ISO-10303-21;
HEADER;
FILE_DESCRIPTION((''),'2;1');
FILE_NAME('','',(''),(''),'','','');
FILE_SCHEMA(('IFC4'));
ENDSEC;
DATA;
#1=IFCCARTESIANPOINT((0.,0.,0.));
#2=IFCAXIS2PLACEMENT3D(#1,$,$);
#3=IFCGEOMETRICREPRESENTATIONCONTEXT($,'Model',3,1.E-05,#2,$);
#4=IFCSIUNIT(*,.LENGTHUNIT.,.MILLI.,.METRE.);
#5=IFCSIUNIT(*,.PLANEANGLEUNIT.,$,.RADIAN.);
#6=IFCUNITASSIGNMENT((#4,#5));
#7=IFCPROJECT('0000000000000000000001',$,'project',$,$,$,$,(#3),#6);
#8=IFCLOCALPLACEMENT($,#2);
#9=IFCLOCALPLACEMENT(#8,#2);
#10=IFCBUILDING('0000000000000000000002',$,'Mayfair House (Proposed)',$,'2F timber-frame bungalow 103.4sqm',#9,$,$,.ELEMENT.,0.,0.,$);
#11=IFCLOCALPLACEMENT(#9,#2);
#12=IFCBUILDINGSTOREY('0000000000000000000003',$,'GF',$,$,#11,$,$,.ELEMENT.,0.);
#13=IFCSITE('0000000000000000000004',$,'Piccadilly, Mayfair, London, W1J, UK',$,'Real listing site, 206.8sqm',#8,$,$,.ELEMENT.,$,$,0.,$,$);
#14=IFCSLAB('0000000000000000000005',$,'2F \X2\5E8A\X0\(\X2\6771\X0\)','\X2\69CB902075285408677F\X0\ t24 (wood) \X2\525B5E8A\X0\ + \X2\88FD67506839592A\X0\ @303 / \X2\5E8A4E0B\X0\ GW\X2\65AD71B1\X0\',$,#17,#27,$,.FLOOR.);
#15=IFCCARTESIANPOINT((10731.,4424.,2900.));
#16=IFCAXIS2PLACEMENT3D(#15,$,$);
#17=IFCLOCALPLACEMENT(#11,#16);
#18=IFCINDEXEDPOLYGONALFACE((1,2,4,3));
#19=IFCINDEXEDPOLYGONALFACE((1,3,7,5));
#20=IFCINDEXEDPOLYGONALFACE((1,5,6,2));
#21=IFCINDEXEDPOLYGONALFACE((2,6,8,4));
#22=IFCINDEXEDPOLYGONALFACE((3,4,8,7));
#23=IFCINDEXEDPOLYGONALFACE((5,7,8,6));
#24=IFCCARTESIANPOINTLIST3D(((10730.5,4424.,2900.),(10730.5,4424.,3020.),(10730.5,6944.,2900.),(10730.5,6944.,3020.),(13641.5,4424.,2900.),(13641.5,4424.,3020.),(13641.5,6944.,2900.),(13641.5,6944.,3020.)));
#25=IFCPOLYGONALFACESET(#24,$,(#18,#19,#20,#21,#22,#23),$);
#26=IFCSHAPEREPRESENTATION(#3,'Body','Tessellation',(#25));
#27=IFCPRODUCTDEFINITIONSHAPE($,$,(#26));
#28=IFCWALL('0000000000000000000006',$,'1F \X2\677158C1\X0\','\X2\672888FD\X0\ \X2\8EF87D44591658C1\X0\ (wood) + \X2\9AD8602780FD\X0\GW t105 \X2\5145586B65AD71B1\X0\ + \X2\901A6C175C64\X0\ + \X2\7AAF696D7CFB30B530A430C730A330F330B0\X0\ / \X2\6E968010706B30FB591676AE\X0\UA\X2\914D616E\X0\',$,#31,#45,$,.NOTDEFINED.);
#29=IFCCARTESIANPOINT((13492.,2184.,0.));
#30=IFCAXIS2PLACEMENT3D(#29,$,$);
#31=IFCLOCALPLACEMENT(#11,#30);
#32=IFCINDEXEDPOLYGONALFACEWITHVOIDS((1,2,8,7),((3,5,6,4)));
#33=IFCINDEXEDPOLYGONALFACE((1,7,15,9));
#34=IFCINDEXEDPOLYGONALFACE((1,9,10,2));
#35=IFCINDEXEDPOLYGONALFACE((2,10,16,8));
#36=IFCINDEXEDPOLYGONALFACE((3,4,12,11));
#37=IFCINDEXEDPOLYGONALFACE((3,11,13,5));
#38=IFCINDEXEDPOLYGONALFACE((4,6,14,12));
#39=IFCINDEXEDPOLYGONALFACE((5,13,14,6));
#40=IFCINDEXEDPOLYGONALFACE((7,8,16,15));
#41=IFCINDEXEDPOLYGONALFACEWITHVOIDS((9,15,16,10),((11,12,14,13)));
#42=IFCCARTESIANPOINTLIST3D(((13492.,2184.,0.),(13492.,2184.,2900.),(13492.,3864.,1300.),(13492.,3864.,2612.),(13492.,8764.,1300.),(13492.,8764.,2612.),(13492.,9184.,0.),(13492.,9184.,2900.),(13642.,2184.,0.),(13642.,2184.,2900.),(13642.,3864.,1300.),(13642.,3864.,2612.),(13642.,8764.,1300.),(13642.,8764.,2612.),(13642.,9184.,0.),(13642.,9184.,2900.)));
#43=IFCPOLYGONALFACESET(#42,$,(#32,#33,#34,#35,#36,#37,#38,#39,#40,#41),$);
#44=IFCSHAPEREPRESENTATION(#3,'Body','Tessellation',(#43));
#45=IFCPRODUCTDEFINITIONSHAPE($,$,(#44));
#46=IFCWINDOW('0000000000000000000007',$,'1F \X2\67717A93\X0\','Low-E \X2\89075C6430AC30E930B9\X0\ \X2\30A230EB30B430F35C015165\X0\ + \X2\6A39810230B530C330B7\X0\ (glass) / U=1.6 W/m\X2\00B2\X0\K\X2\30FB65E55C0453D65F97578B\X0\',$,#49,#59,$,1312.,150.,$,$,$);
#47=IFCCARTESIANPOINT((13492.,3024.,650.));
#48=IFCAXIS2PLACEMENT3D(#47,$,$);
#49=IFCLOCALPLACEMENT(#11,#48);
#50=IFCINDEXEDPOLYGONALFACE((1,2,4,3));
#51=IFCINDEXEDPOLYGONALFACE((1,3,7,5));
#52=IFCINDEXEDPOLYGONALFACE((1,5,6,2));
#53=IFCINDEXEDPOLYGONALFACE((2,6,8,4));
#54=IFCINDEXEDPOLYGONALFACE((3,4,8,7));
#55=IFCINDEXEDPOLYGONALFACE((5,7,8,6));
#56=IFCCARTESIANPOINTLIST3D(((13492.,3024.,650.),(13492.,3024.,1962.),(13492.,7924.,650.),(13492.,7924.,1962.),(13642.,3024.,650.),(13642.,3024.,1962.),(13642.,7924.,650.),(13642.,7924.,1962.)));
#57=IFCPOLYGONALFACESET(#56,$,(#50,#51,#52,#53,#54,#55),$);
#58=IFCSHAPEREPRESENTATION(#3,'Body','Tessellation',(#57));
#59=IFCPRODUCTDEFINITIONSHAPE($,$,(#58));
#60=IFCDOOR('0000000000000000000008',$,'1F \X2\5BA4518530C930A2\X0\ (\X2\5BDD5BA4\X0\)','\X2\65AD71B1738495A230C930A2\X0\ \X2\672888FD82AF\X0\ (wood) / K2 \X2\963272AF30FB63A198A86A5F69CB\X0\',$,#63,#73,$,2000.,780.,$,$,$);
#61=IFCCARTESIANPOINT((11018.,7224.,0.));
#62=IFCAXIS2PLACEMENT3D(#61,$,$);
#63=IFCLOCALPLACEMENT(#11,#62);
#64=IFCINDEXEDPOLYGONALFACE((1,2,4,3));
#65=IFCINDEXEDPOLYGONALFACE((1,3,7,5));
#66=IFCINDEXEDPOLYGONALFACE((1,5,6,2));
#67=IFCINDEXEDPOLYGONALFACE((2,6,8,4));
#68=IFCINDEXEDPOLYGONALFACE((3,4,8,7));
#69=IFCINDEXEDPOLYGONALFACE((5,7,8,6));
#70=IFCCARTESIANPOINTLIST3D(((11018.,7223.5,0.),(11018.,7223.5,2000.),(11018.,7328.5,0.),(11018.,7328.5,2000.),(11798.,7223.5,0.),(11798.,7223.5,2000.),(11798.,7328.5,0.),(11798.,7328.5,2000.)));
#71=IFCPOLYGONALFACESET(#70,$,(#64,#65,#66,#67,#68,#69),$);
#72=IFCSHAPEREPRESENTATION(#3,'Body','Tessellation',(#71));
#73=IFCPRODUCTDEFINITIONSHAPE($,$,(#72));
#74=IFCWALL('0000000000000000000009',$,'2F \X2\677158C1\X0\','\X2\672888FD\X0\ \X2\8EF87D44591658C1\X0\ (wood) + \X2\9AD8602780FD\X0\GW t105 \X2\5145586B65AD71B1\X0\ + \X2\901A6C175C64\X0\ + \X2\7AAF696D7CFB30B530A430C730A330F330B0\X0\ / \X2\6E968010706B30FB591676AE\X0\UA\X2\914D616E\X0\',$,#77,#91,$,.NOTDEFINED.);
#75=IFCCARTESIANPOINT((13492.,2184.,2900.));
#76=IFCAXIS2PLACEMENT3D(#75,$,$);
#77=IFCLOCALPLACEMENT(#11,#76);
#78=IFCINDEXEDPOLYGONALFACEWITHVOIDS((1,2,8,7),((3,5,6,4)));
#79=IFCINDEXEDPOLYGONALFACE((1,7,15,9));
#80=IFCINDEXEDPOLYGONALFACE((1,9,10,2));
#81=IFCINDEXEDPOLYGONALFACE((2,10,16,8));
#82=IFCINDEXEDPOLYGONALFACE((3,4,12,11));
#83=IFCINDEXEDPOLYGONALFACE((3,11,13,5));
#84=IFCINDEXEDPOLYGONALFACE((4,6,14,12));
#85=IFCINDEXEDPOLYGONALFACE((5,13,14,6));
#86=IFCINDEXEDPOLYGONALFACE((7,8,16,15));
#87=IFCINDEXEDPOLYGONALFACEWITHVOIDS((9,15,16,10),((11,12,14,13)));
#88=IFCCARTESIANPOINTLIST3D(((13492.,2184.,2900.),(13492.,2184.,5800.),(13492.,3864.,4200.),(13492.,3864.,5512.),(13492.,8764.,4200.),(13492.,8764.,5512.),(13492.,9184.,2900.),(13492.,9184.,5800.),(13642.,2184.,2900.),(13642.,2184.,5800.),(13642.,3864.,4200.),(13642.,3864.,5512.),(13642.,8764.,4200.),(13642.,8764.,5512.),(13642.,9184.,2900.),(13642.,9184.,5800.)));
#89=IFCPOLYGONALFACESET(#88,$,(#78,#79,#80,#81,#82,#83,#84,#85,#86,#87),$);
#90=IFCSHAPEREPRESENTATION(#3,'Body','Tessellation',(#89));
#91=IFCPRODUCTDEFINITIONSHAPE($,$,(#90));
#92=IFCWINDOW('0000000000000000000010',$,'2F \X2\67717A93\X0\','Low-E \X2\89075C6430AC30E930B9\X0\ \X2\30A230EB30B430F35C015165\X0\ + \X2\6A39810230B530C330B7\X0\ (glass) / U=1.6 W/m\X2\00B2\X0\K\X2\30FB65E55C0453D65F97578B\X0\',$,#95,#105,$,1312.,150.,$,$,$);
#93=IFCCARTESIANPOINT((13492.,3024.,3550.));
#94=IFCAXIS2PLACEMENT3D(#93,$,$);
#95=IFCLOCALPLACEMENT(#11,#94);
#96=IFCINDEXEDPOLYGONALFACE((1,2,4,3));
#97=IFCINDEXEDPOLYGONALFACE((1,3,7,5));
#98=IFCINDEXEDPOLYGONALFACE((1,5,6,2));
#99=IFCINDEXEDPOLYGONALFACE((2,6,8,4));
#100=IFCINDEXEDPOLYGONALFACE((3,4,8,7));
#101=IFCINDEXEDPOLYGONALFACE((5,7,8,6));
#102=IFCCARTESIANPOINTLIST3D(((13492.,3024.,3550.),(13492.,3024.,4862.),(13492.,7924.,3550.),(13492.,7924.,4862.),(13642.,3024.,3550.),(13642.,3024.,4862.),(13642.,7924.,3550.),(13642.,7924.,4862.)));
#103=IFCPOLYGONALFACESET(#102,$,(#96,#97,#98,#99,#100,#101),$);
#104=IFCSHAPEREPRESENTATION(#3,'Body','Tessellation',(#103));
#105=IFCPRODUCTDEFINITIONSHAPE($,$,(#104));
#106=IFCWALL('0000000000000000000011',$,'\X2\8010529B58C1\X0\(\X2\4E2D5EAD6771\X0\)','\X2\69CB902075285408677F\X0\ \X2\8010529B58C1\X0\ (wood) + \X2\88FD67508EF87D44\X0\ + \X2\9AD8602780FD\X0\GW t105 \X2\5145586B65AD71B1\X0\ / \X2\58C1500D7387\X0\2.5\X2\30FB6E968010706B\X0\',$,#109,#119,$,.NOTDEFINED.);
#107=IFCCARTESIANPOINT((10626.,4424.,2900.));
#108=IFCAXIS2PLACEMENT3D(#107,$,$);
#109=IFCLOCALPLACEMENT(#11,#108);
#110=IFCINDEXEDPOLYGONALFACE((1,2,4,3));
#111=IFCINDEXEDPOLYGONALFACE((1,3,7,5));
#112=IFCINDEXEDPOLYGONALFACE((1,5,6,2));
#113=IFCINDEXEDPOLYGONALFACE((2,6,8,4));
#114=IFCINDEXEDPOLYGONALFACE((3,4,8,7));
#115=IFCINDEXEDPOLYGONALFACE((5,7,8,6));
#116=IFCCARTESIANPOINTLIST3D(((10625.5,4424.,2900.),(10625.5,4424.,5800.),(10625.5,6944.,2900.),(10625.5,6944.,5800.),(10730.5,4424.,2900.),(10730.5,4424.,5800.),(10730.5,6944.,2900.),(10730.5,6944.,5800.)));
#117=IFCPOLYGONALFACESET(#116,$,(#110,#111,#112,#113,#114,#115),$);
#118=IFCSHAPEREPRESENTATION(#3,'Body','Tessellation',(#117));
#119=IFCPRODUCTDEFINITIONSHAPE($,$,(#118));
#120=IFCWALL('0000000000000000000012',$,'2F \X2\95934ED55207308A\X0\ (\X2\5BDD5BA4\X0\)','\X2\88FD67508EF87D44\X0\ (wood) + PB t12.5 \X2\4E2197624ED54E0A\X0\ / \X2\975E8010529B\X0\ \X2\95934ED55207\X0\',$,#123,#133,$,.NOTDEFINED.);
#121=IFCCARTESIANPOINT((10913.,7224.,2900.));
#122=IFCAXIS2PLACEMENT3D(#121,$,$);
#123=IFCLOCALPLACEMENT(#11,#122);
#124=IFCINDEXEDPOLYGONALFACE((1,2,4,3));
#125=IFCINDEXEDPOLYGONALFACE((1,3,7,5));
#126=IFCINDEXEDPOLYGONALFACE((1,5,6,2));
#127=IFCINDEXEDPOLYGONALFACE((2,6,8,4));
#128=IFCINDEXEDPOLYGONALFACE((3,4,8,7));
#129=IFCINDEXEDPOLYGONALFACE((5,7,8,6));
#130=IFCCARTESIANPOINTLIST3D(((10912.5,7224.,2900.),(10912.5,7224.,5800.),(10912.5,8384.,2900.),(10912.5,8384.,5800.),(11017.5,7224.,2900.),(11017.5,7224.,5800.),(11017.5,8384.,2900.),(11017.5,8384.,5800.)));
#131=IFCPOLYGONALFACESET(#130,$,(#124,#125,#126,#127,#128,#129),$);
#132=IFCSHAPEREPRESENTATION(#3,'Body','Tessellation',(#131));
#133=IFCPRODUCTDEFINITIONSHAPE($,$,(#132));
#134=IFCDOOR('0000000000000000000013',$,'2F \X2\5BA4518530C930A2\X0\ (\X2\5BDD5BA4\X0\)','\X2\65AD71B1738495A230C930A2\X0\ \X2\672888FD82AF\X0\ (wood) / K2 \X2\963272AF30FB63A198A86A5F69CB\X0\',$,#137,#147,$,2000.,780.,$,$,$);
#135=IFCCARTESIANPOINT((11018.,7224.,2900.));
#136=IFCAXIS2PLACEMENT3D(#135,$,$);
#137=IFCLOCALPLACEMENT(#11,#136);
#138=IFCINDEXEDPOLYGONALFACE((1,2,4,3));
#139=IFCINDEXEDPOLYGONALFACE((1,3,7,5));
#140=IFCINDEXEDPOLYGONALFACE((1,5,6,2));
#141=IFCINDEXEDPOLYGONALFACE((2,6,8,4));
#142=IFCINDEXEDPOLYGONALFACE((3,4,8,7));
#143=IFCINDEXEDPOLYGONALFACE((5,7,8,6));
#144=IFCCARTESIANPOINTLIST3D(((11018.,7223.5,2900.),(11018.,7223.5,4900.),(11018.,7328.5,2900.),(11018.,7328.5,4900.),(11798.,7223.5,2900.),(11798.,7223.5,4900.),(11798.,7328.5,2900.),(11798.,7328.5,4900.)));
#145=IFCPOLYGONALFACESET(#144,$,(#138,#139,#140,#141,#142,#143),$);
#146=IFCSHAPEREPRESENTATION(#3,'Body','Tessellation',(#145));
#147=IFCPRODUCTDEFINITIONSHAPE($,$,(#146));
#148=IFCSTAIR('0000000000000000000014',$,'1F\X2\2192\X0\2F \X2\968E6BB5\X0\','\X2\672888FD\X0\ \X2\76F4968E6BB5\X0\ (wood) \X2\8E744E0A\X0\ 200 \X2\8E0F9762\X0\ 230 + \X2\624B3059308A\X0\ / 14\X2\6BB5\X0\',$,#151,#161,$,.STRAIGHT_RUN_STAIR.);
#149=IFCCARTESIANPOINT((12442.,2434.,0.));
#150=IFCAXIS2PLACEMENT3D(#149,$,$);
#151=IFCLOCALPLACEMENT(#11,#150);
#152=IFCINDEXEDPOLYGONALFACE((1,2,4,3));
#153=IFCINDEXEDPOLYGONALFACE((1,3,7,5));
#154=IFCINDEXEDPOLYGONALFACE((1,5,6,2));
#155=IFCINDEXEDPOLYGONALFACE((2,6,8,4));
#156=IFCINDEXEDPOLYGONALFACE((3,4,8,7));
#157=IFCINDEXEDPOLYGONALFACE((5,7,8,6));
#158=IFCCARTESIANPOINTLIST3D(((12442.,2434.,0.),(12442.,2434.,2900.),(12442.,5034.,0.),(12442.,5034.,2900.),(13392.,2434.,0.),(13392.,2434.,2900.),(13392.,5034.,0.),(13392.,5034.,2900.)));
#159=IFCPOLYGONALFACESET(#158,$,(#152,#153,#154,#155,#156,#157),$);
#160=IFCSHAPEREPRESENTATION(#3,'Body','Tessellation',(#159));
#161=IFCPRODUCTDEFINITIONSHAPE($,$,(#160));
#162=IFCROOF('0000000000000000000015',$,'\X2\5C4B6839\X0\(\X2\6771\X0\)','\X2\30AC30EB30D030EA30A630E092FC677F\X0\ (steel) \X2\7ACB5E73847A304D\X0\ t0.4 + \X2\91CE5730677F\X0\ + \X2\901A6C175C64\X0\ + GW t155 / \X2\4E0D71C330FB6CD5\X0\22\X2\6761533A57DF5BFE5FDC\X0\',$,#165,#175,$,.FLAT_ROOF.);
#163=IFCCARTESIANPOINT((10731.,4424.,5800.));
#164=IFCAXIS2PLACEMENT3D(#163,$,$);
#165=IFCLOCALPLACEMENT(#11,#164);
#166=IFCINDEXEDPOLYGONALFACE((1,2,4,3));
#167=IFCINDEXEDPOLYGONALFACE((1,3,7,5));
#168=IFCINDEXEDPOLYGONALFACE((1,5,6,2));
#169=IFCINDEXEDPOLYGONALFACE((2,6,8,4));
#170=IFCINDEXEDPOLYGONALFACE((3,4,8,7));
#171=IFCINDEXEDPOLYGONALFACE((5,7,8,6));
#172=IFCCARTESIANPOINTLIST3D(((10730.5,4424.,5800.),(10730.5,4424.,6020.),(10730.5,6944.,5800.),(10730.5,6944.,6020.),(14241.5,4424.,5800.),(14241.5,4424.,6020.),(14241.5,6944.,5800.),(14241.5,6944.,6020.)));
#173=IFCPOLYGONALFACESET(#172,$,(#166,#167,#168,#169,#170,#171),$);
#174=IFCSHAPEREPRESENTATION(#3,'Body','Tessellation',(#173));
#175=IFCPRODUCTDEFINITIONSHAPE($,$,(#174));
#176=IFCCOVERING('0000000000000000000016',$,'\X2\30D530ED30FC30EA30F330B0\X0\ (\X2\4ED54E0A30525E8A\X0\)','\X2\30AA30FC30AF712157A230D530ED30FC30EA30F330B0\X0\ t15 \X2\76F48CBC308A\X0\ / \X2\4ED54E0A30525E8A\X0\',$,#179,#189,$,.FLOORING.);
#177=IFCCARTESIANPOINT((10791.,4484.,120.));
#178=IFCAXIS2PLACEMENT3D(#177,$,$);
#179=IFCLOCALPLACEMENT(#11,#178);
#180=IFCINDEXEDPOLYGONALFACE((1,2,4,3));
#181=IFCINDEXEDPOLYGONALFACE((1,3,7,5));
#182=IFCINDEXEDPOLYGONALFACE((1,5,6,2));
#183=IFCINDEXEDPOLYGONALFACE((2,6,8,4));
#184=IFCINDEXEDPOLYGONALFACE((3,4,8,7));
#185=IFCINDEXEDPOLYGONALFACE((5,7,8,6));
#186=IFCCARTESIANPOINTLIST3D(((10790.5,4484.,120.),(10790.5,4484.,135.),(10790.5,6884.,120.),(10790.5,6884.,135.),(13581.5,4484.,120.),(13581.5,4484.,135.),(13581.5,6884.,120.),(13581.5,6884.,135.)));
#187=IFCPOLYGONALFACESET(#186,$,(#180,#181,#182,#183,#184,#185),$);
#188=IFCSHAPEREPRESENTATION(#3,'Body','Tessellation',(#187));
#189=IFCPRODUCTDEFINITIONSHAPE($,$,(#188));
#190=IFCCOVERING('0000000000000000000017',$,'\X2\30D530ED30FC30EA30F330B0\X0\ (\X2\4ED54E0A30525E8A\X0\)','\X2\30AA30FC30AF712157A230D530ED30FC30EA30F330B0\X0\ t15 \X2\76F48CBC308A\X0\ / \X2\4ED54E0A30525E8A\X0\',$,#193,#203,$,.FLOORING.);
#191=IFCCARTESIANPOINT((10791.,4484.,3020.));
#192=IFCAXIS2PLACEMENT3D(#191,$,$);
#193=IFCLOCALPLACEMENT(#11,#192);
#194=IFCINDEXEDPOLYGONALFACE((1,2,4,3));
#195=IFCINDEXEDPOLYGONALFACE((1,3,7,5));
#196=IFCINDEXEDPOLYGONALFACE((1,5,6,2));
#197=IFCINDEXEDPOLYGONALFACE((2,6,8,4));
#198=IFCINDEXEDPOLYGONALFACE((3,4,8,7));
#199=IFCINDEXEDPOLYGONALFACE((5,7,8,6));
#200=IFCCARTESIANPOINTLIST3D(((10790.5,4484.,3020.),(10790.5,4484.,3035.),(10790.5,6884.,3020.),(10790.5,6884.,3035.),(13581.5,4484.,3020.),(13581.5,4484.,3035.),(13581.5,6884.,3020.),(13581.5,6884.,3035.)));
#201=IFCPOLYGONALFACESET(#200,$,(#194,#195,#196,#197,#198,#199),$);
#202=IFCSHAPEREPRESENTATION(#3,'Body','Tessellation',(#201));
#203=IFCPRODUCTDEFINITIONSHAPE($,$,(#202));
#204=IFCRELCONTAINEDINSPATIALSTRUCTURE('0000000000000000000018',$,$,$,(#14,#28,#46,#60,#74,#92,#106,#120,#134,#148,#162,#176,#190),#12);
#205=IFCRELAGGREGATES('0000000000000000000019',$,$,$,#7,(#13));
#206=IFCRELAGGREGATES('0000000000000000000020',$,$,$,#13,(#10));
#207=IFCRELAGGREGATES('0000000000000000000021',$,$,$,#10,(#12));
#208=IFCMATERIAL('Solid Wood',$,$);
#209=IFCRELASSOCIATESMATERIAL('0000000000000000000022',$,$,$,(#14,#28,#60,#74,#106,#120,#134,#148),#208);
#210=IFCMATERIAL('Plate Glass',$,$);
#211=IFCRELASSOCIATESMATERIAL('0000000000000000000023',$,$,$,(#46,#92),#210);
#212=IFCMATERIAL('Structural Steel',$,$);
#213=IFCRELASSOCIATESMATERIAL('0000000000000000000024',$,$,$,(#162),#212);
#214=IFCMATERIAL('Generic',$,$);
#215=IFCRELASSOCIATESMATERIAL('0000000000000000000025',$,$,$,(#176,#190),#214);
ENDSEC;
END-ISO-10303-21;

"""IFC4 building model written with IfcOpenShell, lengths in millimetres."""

from ifc_helpers import new_model, si_unit, frame, frame_2d, origin, place, context, project, spatial, rectangle, extrude, material, element, fill, save


model = new_model("IFC4")

# Units and contexts
model_context = context("Model", 3, precision=1e-05, world=origin())
ifc_project = project(units=[si_unit("LENGTHUNIT", "METRE", prefix="MILLI"), si_unit("PLANEANGLEUNIT", "RADIAN")], contexts=[model_context])

# Site, building, storey
site_placement = place(None, origin())
site = spatial("IfcSite", under=ifc_project, at=site_placement, Name="Piccadilly, Mayfair, London, W1J, UK", ObjectType="Real listing site, 206.8sqm", CompositionType="ELEMENT", RefElevation=0.0)
building_placement = place(site_placement, origin())
building = spatial("IfcBuilding", under=site, at=building_placement, Name="Mayfair House (Proposed)", ObjectType="2F timber-frame bungalow 103.4sqm", CompositionType="ELEMENT", ElevationOfRefHeight=0.0, ElevationOfTerrain=0.0)
storey_placement = place(building_placement, origin())
storey = spatial("IfcBuildingStorey", under=building, at=storey_placement, Name="GF", CompositionType="ELEMENT", Elevation=0.0)

# Slab
ifc_material_1 = material(Name="Solid Wood")
slab_1_placement = place(storey_placement, frame((10731.0, 4424.0, 2900.0)))
element("IfcSlab", 1, at=slab_1_placement, inside=storey, material=ifc_material_1, Name="2F 床(東)", Description="構造用合板 t24 (wood) 剛床 + 製材根太 @303 / 床下 GW断熱", PredefinedType="FLOOR", context=model_context, shape_type="SweptSolid", body=[
    extrude(rectangle(XDim=2911.0, YDim=2520.0, at=frame_2d((1455.0, 1260.0))), frame((10731.0, 4424.0, 2900.0)), (0.0, 0.0, 1.0), 120.0),
])

# Wall, opening, window
wall_1_placement = place(storey_placement, frame((13492.0, 2184.0, 0.0)))
wall_1 = element("IfcWall", 2, at=wall_1_placement, inside=storey, material=ifc_material_1, Name="1F 東壁", Description="木製 軸組外壁 (wood) + 高性能GW t105 充填断熱 + 通気層 + 窯業系サイディング / 準耐火・外皮UA配慮", PredefinedType="NOTDEFINED", context=model_context, shape_type="SweptSolid", body=[
    extrude(rectangle(XDim=150.0, YDim=7000.0, at=frame_2d((75.0, 3500.0))), frame((13492.0, 2184.0, 0.0)), (0.0, 0.0, 1.0), 2900.0),
])
opening_1_placement = place(storey_placement, frame((13492.0, 3024.0, 650.0)))
opening_1 = element("IfcOpeningElement", 3, at=opening_1_placement, cuts=wall_1, PredefinedType="NOTDEFINED", context=model_context, shape_type="SweptSolid", body=[
    extrude(rectangle(XDim=150.0, YDim=4900.0, at=frame_2d((75.0, 2450.0))), frame((13492.0, 3024.0, 650.0)), (0.0, 0.0, 1.0), 1312.0),
])
ifc_material_2 = material(Name="Plate Glass")
window_1_placement = place(storey_placement, frame((13492.0, 3024.0, 650.0)))
window_1 = element("IfcWindow", 4, at=window_1_placement, inside=storey, material=ifc_material_2, Name="1F 東窓", Description="Low-E 複層ガラス アルゴン封入 + 樹脂サッシ (glass) / U=1.6 W/m²K・日射取得型", OverallHeight=1312.0, OverallWidth=150.0, context=model_context, shape_type="SweptSolid", body=[
    extrude(rectangle(XDim=150.0, YDim=4900.0, at=frame_2d((75.0, 2450.0))), frame((13492.0, 3024.0, 650.0)), (0.0, 0.0, 1.0), 1312.0),
])
fill(opening_1, window_1)

# Door
door_1_placement = place(storey_placement, frame((11018.0, 7224.0, 0.0)))
element("IfcDoor", 5, at=door_1_placement, inside=storey, material=ifc_material_1, Name="1F 室内ドア (寝室)", Description="断熱玄関ドア 木製芯 (wood) / K2 防犯・採風機構", OverallHeight=2000.0, OverallWidth=780.0, context=model_context, shape_type="SweptSolid", body=[
    extrude(rectangle(XDim=780.0, YDim=105.0, at=frame_2d((390.0, 52.0))), frame((11018.0, 7224.0, 0.0)), (0.0, 0.0, 1.0), 2000.0),
])

# Wall, opening, window
wall_2_placement = place(storey_placement, frame((13492.0, 2184.0, 2900.0)))
wall_2 = element("IfcWall", 6, at=wall_2_placement, inside=storey, material=ifc_material_1, Name="2F 東壁", Description="木製 軸組外壁 (wood) + 高性能GW t105 充填断熱 + 通気層 + 窯業系サイディング / 準耐火・外皮UA配慮", PredefinedType="NOTDEFINED", context=model_context, shape_type="SweptSolid", body=[
    extrude(rectangle(XDim=150.0, YDim=7000.0, at=frame_2d((75.0, 3500.0))), frame((13492.0, 2184.0, 2900.0)), (0.0, 0.0, 1.0), 2900.0),
])
opening_2_placement = place(storey_placement, frame((13492.0, 3024.0, 3550.0)))
opening_2 = element("IfcOpeningElement", 7, at=opening_2_placement, cuts=wall_2, PredefinedType="NOTDEFINED", context=model_context, shape_type="SweptSolid", body=[
    extrude(rectangle(XDim=150.0, YDim=4900.0, at=frame_2d((75.0, 2450.0))), frame((13492.0, 3024.0, 3550.0)), (0.0, 0.0, 1.0), 1312.0),
])
window_2_placement = place(storey_placement, frame((13492.0, 3024.0, 3550.0)))
window_2 = element("IfcWindow", 8, at=window_2_placement, inside=storey, material=ifc_material_2, Name="2F 東窓", Description="Low-E 複層ガラス アルゴン封入 + 樹脂サッシ (glass) / U=1.6 W/m²K・日射取得型", OverallHeight=1312.0, OverallWidth=150.0, context=model_context, shape_type="SweptSolid", body=[
    extrude(rectangle(XDim=150.0, YDim=4900.0, at=frame_2d((75.0, 2450.0))), frame((13492.0, 3024.0, 3550.0)), (0.0, 0.0, 1.0), 1312.0),
])
fill(opening_2, window_2)

# Walls
wall_3_placement = place(storey_placement, frame((10626.0, 4424.0, 2900.0)))
element("IfcWall", 9, at=wall_3_placement, inside=storey, material=ifc_material_1, Name="耐力壁(中庭東)", Description="構造用合板 耐力壁 (wood) + 製材軸組 + 高性能GW t105 充填断熱 / 壁倍率2.5・準耐火", PredefinedType="NOTDEFINED", context=model_context, shape_type="SweptSolid", body=[
    extrude(rectangle(XDim=105.0, YDim=2520.0, at=frame_2d((52.0, 1260.0))), frame((10626.0, 4424.0, 2900.0)), (0.0, 0.0, 1.0), 2900.0),
])
wall_4_placement = place(storey_placement, frame((10913.0, 7224.0, 2900.0)))
element("IfcWall", 10, at=wall_4_placement, inside=storey, material=ifc_material_1, Name="2F 間仕切り (寝室)", Description="製材軸組 (wood) + PB t12.5 両面仕上 / 非耐力 間仕切", PredefinedType="NOTDEFINED", context=model_context, shape_type="SweptSolid", body=[
    extrude(rectangle(XDim=105.0, YDim=1160.0, at=frame_2d((52.0, 580.0))), frame((10913.0, 7224.0, 2900.0)), (0.0, 0.0, 1.0), 2900.0),
])

# Door
door_2_placement = place(storey_placement, frame((11018.0, 7224.0, 2900.0)))
element("IfcDoor", 11, at=door_2_placement, inside=storey, material=ifc_material_1, Name="2F 室内ドア (寝室)", Description="断熱玄関ドア 木製芯 (wood) / K2 防犯・採風機構", OverallHeight=2000.0, OverallWidth=780.0, context=model_context, shape_type="SweptSolid", body=[
    extrude(rectangle(XDim=780.0, YDim=105.0, at=frame_2d((390.0, 52.0))), frame((11018.0, 7224.0, 2900.0)), (0.0, 0.0, 1.0), 2000.0),
])

# Stair
stair_placement = place(storey_placement, frame((12442.0, 2434.0, 0.0)))
element("IfcStair", 12, at=stair_placement, inside=storey, material=ifc_material_1, Name="1F→2F 階段", Description="木製 直階段 (wood) 蹴上 200 踏面 230 + 手すり / 14段", PredefinedType="STRAIGHT_RUN_STAIR", context=model_context, shape_type="SweptSolid", body=[
    extrude(rectangle(XDim=950.0, YDim=2600.0, at=frame_2d((475.0, 1300.0))), frame((12442.0, 2434.0, 0.0)), (0.0, 0.0, 1.0), 2900.0),
])

# Roof
ifc_material_3 = material(Name="Structural Steel")
for number, where, name in (
    (13, (10731.0, 4424.0, 5800.0), "屋根(東)"),
):
    element("IfcRoof", number, at=place(storey_placement, frame(where)), inside=storey, material=ifc_material_3, Name=name, Description="ガルバリウム鋼板 (steel) 立平葺き t0.4 + 野地板 + 通気層 + GW t155 / 不燃・法22条区域対応", PredefinedType="FLAT_ROOF", context=model_context, shape_type="SweptSolid", body=[
        extrude(rectangle(XDim=3511.0, YDim=2520.0, at=frame_2d((1755.0, 1260.0))), frame((10731.0, 4424.0, 5800.0)), (0.0, 0.0, 1.0), 220.0),
    ])

# Coverings
ifc_material_4 = material(Name="Generic")
covering_1_placement = place(storey_placement, frame((10791.0, 4484.0, 120.0)))
element("IfcCovering", 14, at=covering_1_placement, inside=storey, material=ifc_material_4, Name="フローリング (仕上げ床)", Description="オーク無垢フローリング t15 直貼り / 仕上げ床", PredefinedType="FLOORING", context=model_context, shape_type="SweptSolid", body=[
    extrude(rectangle(XDim=2791.0, YDim=2400.0, at=frame_2d((1395.0, 1200.0))), frame((10791.0, 4484.0, 120.0)), (0.0, 0.0, 1.0), 15.0),
])
covering_2_placement = place(storey_placement, frame((10791.0, 4484.0, 3020.0)))
element("IfcCovering", 15, at=covering_2_placement, inside=storey, material=ifc_material_4, Name="フローリング (仕上げ床)", Description="オーク無垢フローリング t15 直貼り / 仕上げ床", PredefinedType="FLOORING", context=model_context, shape_type="SweptSolid", body=[
    extrude(rectangle(XDim=2791.0, YDim=2400.0, at=frame_2d((1395.0, 1200.0))), frame((10791.0, 4484.0, 3020.0)), (0.0, 0.0, 1.0), 15.0),
])

save(model, "model.ifc")
